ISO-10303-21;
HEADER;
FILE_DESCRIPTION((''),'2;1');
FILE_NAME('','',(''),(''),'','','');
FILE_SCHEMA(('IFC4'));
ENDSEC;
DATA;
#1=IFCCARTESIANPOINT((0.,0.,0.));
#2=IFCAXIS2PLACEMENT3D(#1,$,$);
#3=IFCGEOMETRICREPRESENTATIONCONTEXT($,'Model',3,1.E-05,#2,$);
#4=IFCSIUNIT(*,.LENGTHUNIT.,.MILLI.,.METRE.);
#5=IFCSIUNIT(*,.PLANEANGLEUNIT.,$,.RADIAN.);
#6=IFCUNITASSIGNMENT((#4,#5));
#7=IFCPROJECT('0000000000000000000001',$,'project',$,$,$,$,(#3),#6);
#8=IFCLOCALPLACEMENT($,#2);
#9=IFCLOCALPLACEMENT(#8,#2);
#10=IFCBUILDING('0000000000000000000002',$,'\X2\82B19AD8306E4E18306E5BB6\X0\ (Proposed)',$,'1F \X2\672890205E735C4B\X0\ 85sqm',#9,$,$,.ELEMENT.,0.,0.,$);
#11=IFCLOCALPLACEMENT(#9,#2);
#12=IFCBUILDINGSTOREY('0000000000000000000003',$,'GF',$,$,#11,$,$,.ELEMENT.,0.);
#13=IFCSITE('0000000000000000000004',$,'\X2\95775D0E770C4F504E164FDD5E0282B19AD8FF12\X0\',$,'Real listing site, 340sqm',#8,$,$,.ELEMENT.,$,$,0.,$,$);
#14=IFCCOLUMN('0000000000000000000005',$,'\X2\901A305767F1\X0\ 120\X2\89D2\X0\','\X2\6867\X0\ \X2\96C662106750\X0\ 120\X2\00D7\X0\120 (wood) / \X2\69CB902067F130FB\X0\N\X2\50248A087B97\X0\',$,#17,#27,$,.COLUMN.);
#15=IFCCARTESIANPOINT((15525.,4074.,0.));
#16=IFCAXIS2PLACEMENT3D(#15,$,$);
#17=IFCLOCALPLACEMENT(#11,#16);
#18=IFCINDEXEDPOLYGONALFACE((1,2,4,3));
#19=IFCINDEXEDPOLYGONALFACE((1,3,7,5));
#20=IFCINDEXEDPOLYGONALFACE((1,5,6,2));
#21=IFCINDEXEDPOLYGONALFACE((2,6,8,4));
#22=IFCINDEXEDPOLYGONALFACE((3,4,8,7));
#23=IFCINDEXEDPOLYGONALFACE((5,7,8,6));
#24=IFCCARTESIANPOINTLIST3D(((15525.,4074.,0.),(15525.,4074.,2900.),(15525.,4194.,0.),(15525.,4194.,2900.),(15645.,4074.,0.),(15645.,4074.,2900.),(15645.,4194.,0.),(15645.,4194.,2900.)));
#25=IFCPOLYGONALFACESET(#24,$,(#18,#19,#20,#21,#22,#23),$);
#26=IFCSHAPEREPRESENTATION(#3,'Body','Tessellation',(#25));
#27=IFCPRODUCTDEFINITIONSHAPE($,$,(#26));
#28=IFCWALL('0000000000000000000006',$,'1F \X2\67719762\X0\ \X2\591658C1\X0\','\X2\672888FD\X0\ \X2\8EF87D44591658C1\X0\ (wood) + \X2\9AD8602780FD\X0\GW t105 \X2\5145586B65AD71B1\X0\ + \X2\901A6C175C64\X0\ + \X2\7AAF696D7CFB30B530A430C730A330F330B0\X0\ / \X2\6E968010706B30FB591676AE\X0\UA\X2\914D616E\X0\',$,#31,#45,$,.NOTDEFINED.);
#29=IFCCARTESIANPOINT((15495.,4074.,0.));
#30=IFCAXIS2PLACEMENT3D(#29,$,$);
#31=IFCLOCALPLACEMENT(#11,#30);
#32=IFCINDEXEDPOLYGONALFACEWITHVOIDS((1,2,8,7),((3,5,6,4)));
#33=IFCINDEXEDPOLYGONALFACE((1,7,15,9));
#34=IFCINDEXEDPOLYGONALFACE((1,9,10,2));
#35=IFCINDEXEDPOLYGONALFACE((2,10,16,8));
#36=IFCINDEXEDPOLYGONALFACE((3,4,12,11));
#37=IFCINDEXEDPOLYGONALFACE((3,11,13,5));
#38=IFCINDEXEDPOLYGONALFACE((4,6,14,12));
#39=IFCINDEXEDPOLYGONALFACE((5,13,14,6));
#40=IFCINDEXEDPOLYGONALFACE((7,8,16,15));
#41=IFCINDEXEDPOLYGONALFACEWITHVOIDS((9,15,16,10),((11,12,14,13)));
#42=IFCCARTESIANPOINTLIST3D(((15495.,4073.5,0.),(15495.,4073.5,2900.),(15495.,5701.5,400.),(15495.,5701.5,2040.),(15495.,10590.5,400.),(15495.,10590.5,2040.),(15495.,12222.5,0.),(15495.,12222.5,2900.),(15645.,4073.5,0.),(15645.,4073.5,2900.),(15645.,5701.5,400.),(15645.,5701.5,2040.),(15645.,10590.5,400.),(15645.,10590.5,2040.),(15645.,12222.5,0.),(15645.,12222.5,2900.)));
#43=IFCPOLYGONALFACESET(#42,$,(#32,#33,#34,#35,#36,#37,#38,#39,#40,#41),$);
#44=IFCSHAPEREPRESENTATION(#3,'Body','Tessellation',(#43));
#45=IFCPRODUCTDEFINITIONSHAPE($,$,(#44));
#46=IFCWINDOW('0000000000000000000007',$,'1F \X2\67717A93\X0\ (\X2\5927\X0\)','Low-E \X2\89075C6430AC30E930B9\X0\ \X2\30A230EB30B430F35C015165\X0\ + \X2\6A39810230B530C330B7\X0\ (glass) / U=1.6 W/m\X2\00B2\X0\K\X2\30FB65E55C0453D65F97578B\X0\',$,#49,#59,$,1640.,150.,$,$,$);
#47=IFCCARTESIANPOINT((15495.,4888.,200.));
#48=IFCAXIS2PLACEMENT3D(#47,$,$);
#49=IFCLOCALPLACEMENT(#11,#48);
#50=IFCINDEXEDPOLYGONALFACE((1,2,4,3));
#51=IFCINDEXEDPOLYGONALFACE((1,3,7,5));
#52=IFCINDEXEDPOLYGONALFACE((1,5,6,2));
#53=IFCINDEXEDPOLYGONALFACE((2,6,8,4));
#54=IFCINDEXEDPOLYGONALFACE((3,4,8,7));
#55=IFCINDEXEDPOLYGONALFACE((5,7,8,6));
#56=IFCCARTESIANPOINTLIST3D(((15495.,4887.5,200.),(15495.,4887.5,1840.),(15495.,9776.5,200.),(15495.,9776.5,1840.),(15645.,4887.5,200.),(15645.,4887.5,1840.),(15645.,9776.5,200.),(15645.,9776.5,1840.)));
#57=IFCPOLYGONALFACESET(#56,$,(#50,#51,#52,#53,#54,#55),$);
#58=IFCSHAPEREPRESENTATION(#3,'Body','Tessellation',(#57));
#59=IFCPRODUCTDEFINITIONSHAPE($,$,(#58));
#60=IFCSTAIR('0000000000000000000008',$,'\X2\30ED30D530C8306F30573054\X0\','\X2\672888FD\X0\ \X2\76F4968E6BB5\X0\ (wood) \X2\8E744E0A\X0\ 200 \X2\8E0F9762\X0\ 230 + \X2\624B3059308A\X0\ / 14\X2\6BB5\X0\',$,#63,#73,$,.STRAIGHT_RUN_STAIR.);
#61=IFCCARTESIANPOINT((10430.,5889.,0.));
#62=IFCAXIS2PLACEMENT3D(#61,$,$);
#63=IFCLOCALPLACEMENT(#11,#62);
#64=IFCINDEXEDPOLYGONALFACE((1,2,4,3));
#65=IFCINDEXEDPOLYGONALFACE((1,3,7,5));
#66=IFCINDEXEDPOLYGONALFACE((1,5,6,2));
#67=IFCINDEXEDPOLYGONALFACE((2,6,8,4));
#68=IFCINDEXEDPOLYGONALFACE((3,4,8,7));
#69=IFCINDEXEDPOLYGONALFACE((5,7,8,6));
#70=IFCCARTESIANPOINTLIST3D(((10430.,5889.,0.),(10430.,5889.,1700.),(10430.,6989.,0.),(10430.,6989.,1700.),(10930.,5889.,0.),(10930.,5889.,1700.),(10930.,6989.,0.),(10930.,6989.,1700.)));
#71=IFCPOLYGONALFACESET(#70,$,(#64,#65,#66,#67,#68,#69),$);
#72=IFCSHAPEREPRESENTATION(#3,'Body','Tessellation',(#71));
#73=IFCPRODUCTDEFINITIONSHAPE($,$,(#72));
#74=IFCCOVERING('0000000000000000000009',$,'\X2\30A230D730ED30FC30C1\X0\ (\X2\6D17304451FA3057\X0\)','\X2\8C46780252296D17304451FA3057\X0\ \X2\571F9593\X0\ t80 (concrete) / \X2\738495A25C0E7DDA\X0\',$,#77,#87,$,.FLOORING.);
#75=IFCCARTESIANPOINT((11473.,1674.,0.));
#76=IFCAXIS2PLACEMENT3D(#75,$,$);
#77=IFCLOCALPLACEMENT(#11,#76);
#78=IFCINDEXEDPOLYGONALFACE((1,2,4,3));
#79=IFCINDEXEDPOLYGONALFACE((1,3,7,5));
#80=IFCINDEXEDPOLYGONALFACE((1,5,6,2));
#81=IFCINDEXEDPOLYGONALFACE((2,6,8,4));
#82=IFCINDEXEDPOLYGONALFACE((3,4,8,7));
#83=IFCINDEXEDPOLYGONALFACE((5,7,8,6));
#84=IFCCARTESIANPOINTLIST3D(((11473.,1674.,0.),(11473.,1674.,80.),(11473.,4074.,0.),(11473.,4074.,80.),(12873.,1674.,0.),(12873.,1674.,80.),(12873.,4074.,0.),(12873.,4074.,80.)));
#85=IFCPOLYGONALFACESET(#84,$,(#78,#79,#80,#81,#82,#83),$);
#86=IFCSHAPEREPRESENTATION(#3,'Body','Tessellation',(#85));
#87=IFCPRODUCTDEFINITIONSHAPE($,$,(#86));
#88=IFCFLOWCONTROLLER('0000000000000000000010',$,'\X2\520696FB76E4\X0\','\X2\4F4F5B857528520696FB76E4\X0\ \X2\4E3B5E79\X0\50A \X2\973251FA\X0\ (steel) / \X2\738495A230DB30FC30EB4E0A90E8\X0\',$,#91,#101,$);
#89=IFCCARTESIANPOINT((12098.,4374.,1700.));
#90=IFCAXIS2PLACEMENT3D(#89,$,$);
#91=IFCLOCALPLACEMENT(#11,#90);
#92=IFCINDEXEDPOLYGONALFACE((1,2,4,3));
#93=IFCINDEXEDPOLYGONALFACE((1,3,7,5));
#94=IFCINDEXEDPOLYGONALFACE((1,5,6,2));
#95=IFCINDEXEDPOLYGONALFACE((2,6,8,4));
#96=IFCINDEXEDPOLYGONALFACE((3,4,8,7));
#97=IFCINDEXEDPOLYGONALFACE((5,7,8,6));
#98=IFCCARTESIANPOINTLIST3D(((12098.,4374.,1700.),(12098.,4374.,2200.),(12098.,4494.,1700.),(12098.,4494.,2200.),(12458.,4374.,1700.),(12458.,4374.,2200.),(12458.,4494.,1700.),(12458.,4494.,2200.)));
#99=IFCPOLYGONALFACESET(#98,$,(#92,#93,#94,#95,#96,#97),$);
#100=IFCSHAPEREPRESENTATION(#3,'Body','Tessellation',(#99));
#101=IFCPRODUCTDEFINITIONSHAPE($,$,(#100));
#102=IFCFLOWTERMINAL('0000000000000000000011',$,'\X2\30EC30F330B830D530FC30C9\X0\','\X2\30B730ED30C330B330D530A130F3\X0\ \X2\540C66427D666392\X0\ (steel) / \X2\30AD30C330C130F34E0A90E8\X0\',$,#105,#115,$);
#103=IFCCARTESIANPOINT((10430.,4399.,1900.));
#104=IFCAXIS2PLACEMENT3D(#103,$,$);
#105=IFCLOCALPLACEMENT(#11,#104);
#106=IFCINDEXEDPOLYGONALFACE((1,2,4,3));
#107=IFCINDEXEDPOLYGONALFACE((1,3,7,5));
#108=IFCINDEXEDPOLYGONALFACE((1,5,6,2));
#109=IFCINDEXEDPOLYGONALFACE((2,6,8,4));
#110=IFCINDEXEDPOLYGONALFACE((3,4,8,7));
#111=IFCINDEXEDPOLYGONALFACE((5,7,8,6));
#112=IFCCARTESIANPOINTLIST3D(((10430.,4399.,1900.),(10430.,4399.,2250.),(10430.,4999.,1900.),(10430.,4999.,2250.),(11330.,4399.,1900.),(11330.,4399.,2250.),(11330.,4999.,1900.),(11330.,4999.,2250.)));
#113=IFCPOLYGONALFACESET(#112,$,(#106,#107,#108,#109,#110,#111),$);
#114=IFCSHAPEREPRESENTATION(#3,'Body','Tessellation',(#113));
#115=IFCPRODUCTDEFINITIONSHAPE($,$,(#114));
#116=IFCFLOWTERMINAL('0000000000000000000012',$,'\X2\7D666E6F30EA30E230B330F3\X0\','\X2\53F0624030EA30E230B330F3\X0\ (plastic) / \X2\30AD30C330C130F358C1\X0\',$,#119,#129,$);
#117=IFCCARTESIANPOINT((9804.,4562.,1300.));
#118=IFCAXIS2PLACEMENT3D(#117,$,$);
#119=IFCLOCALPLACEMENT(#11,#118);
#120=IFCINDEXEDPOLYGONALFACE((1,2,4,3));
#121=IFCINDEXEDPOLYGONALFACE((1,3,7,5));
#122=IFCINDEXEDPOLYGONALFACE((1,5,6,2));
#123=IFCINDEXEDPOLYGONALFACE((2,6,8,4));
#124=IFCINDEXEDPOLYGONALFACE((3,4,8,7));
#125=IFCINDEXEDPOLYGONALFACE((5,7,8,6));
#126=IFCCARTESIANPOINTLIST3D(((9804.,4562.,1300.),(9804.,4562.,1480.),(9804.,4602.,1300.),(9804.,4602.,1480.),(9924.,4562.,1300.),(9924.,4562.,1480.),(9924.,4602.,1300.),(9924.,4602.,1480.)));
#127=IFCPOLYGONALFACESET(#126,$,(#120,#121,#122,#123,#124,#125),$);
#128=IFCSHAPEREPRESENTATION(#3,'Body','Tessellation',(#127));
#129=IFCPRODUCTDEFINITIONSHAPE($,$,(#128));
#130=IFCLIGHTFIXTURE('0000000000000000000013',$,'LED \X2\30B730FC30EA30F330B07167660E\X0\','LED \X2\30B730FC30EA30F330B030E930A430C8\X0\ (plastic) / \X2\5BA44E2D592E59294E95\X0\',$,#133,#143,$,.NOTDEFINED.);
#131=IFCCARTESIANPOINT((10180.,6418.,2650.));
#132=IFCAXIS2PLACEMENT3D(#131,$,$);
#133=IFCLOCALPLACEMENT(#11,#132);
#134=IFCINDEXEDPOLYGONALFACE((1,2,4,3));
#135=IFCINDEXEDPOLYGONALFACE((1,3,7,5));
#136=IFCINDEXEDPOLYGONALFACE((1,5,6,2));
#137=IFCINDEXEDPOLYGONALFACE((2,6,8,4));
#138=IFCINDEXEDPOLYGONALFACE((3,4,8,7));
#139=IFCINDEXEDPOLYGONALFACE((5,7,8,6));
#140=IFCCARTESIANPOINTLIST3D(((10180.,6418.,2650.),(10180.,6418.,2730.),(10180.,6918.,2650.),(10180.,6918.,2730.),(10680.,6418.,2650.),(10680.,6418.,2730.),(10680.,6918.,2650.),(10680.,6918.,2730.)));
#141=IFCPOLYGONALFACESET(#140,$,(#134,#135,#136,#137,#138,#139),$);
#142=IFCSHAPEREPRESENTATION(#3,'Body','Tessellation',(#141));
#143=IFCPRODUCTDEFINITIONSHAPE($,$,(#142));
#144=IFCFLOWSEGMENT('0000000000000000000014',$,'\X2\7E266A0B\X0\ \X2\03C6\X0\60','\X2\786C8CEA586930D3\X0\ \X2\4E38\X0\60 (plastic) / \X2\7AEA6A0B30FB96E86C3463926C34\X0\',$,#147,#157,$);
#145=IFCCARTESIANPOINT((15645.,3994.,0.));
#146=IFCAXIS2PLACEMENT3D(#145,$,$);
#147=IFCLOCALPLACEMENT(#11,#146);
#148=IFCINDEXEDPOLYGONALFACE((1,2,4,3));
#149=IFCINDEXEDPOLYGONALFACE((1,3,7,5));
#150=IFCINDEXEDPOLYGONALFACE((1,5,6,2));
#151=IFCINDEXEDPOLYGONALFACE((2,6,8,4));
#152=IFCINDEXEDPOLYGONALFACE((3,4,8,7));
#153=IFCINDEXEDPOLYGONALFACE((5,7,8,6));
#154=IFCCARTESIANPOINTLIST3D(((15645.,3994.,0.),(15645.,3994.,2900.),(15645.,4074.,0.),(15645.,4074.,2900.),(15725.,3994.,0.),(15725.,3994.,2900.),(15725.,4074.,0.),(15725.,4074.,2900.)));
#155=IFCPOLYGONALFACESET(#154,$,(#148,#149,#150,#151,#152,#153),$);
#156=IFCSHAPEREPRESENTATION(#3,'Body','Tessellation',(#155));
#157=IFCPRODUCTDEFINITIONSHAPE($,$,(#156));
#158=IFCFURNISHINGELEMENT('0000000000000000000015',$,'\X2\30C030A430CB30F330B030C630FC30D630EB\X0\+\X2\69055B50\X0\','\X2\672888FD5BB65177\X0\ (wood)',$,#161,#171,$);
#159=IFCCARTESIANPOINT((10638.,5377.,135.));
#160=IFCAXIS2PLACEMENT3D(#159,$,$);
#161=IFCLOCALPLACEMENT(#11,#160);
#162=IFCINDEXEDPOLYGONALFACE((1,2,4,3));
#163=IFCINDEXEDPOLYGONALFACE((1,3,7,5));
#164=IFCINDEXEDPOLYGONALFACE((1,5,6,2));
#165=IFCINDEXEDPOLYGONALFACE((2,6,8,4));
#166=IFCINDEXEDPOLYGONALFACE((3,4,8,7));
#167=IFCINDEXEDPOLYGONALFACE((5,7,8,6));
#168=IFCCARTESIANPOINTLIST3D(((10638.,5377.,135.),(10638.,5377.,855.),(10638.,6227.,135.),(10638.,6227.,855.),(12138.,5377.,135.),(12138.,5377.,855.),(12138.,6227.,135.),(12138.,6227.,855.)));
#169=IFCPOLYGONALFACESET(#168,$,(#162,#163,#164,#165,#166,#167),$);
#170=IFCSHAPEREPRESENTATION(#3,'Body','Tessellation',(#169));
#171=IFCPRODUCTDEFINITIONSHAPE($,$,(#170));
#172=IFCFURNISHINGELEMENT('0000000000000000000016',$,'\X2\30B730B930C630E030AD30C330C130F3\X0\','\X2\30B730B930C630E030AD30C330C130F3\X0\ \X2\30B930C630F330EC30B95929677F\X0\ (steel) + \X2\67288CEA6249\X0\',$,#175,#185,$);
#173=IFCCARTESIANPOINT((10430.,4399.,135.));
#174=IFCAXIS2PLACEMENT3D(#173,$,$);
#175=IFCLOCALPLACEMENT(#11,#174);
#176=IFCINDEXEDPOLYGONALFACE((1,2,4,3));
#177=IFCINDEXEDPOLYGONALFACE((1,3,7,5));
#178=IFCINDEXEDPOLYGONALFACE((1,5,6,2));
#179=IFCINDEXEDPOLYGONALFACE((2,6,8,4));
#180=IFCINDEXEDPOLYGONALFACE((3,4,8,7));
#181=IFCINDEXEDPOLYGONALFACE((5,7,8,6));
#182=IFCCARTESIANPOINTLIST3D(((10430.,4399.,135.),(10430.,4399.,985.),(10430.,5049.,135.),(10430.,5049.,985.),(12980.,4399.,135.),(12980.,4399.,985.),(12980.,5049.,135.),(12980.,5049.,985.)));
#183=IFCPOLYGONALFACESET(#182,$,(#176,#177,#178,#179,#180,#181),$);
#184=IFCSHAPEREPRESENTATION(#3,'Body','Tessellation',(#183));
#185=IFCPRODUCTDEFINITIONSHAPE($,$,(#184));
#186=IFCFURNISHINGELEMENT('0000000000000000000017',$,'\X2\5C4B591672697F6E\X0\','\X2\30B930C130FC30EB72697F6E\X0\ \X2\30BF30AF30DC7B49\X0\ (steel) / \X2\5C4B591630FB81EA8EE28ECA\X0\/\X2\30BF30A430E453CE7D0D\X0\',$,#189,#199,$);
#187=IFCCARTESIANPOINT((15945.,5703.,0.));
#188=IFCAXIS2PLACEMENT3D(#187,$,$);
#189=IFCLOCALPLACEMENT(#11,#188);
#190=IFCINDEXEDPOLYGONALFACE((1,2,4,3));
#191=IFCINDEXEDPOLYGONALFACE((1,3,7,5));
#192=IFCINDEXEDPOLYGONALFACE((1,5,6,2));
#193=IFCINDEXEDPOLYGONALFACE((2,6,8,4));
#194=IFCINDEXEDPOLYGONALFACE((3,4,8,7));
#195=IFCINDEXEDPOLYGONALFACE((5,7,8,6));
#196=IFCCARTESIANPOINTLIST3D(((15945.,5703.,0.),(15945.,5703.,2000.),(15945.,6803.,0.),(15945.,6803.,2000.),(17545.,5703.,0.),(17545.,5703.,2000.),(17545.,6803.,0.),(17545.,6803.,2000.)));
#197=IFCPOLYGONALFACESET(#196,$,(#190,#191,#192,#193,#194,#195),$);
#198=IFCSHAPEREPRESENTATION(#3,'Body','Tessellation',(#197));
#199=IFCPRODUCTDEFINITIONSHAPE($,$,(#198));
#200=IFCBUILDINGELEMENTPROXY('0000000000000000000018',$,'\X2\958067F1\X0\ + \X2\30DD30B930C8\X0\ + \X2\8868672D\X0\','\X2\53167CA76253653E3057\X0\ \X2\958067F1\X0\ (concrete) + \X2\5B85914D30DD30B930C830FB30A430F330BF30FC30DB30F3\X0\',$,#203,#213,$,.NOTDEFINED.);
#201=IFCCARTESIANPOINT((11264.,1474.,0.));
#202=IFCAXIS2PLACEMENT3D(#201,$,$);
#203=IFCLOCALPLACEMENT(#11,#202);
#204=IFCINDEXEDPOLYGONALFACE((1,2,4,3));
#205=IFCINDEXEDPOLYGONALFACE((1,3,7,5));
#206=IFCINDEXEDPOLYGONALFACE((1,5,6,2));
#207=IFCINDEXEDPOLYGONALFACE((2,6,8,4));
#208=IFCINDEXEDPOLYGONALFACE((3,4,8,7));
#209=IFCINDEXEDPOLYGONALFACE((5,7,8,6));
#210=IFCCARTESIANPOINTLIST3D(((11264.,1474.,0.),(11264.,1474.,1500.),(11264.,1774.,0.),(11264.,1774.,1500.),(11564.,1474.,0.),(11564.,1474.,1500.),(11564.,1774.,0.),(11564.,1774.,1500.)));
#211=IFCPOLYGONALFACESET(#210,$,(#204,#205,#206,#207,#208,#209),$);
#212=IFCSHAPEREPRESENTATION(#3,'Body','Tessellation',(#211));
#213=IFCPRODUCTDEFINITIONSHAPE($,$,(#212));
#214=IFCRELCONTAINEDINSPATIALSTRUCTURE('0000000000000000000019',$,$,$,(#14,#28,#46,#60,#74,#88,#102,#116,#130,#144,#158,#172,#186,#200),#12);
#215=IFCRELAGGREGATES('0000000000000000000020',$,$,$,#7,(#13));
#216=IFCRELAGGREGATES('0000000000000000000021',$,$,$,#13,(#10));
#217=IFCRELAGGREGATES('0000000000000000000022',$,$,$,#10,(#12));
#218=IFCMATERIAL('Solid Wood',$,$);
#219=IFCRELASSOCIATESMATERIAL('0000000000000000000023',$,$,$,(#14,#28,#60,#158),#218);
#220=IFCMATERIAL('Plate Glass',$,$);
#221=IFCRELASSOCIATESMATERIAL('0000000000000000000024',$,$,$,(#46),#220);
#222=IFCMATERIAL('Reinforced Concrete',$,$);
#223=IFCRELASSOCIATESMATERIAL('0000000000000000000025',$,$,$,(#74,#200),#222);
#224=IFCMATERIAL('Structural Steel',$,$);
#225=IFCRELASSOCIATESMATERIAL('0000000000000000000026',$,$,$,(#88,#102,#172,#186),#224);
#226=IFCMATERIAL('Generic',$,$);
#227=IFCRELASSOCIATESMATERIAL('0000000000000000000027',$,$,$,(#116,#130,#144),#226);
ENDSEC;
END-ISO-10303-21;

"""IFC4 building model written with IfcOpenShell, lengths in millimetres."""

from ifc_helpers import new_model, si_unit, frame, frame_2d, origin, place, context, project, spatial, rectangle, extrude, material, element, fill, save


model = new_model("IFC4")

# Units and contexts
model_context = context("Model", 3, precision=1e-05, world=origin())
ifc_project = project(units=[si_unit("LENGTHUNIT", "METRE", prefix="MILLI"), si_unit("PLANEANGLEUNIT", "RADIAN")], contexts=[model_context])

# Site, building, storey
site_placement = place(None, origin())
site = spatial("IfcSite", under=ifc_project, at=site_placement, Name="長崎県佐世保市花高２", ObjectType="Real listing site, 340sqm", CompositionType="ELEMENT", RefElevation=0.0)
building_placement = place(site_placement, origin())
building = spatial("IfcBuilding", under=site, at=building_placement, Name="花高の丘の家 (Proposed)", ObjectType="1F 木造平屋 85sqm", CompositionType="ELEMENT", ElevationOfRefHeight=0.0, ElevationOfTerrain=0.0)
storey_placement = place(building_placement, origin())
storey = spatial("IfcBuildingStorey", under=building, at=storey_placement, Name="GF", CompositionType="ELEMENT", Elevation=0.0)

# Column
ifc_material_1 = material(Name="Solid Wood")
column_1_placement = place(storey_placement, frame((15525.0, 4074.0, 0.0)))
element("IfcColumn", 1, at=column_1_placement, inside=storey, material=ifc_material_1, Name="通し柱 120角", Description="桧 集成材 120×120 (wood) / 構造柱・N値計算", PredefinedType="COLUMN", context=model_context, shape_type="SweptSolid", body=[
    extrude(rectangle(XDim=120.0, YDim=120.0, at=frame_2d((60.0, 60.0))), frame((15525.0, 4074.0, 0.0)), (0.0, 0.0, 1.0), 2900.0),
])

# Wall, opening, window
wall_1_placement = place(storey_placement, frame((15495.0, 4074.0, 0.0)))
wall_1 = element("IfcWall", 2, at=wall_1_placement, inside=storey, material=ifc_material_1, Name="1F 東面 外壁", Description="木製 軸組外壁 (wood) + 高性能GW t105 充填断熱 + 通気層 + 窯業系サイディング / 準耐火・外皮UA配慮", PredefinedType="NOTDEFINED", context=model_context, shape_type="SweptSolid", body=[
    extrude(rectangle(XDim=150.0, YDim=8149.0, at=frame_2d((75.0, 4074.0))), frame((15495.0, 4074.0, 0.0)), (0.0, 0.0, 1.0), 2900.0),
])
opening_placement = place(storey_placement, frame((15495.0, 4888.0, 200.0)))
opening = element("IfcOpeningElement", 3, at=opening_placement, cuts=wall_1, PredefinedType="NOTDEFINED", context=model_context, shape_type="SweptSolid", body=[
    extrude(rectangle(XDim=150.0, YDim=4889.0, at=frame_2d((75.0, 2444.0))), frame((15495.0, 4888.0, 200.0)), (0.0, 0.0, 1.0), 1640.0),
])
ifc_material_2 = material(Name="Plate Glass")
window_placement = place(storey_placement, frame((15495.0, 4888.0, 200.0)))
window = element("IfcWindow", 4, at=window_placement, inside=storey, material=ifc_material_2, Name="1F 東窓 (大)", Description="Low-E 複層ガラス アルゴン封入 + 樹脂サッシ (glass) / U=1.6 W/m²K・日射取得型", OverallHeight=1640.0, OverallWidth=150.0, context=model_context, shape_type="SweptSolid", body=[
    extrude(rectangle(XDim=150.0, YDim=4889.0, at=frame_2d((75.0, 2444.0))), frame((15495.0, 4888.0, 200.0)), (0.0, 0.0, 1.0), 1640.0),
])
fill(opening, window)

# Stair
stair_placement = place(storey_placement, frame((10430.0, 5889.0, 0.0)))
element("IfcStair", 5, at=stair_placement, inside=storey, material=ifc_material_1, Name="ロフトはしご", Description="木製 直階段 (wood) 蹴上 200 踏面 230 + 手すり / 14段", PredefinedType="STRAIGHT_RUN_STAIR", context=model_context, shape_type="SweptSolid", body=[
    extrude(rectangle(XDim=500.0, YDim=1100.0, at=frame_2d((250.0, 550.0))), frame((10430.0, 5889.0, 0.0)), (0.0, 0.0, 1.0), 1700.0),
])

# Covering
ifc_material_3 = material(Name="Reinforced Concrete")
covering_placement = place(storey_placement, frame((11473.0, 1674.0, 0.0)))
element("IfcCovering", 6, at=covering_placement, inside=storey, material=ifc_material_3, Name="アプローチ (洗い出し)", Description="豆砂利洗い出し 土間 t80 (concrete) / 玄関導線", PredefinedType="FLOORING", context=model_context, shape_type="SweptSolid", body=[
    extrude(rectangle(XDim=1400.0, YDim=2400.0, at=frame_2d((700.0, 1200.0))), frame((11473.0, 1674.0, 0.0)), (0.0, 0.0, 1.0), 80.0),
])

# Flow controller
ifc_material_4 = material(Name="Structural Steel")
flow_controller_placement = place(storey_placement, frame((12098.0, 4374.0, 1700.0)))
element("IfcFlowController", 7, at=flow_controller_placement, inside=storey, material=ifc_material_4, Name="分電盤", Description="住宅用分電盤 主幹50A 露出 (steel) / 玄関ホール上部", context=model_context, shape_type="SweptSolid", body=[
    extrude(rectangle(XDim=360.0, YDim=120.0, at=frame_2d((180.0, 60.0))), frame((12098.0, 4374.0, 1700.0)), (0.0, 0.0, 1.0), 500.0),
])

# Flow terminals
flow_terminal_1_placement = place(storey_placement, frame((10430.0, 4399.0, 1900.0)))
element("IfcFlowTerminal", 8, at=flow_terminal_1_placement, inside=storey, material=ifc_material_4, Name="レンジフード", Description="シロッコファン 同時給排 (steel) / キッチン上部", context=model_context, shape_type="SweptSolid", body=[
    extrude(rectangle(XDim=900.0, YDim=600.0, at=frame_2d((450.0, 300.0))), frame((10430.0, 4399.0, 1900.0)), (0.0, 0.0, 1.0), 350.0),
])
ifc_material_5 = material(Name="Generic")
flow_terminal_2_placement = place(storey_placement, frame((9804.0, 4562.0, 1300.0)))
element("IfcFlowTerminal", 9, at=flow_terminal_2_placement, inside=storey, material=ifc_material_5, Name="給湯リモコン", Description="台所リモコン (plastic) / キッチン壁", context=model_context, shape_type="SweptSolid", body=[
    extrude(rectangle(XDim=120.0, YDim=40.0, at=frame_2d((60.0, 20.0))), frame((9804.0, 4562.0, 1300.0)), (0.0, 0.0, 1.0), 180.0),
])

# Light fixture
light_fixture_placement = place(storey_placement, frame((10180.0, 6418.0, 2650.0)))
element("IfcLightFixture", 10, at=light_fixture_placement, inside=storey, material=ifc_material_5, Name="LED シーリング照明", Description="LED シーリングライト (plastic) / 室中央天井", PredefinedType="NOTDEFINED", context=model_context, shape_type="SweptSolid", body=[
    extrude(rectangle(XDim=500.0, YDim=500.0, at=frame_2d((250.0, 250.0))), frame((10180.0, 6418.0, 2650.0)), (0.0, 0.0, 1.0), 80.0),
])

# Flow segment
flow_segment_placement = place(storey_placement, frame((15645.0, 3994.0, 0.0)))
element("IfcFlowSegment", 11, at=flow_segment_placement, inside=storey, material=ifc_material_5, Name="縦樋 φ60", Description="硬質塩ビ 丸60 (plastic) / 竪樋・雨水排水", context=model_context, shape_type="SweptSolid", body=[
    extrude(rectangle(XDim=80.0, YDim=80.0, at=frame_2d((40.0, 40.0))), frame((15645.0, 3994.0, 0.0)), (0.0, 0.0, 1.0), 2900.0),
])

# Furnishing elements
furnishing_1_placement = place(storey_placement, frame((10638.0, 5377.0, 135.0)))
element("IfcFurnishingElement", 12, at=furnishing_1_placement, inside=storey, material=ifc_material_1, Name="ダイニングテーブル+椅子", Description="木製家具 (wood)", context=model_context, shape_type="SweptSolid", body=[
    extrude(rectangle(XDim=1500.0, YDim=850.0, at=frame_2d((750.0, 425.0))), frame((10638.0, 5377.0, 135.0)), (0.0, 0.0, 1.0), 720.0),
])
furnishing_2_placement = place(storey_placement, frame((10430.0, 4399.0, 135.0)))
element("IfcFurnishingElement", 13, at=furnishing_2_placement, inside=storey, material=ifc_material_4, Name="システムキッチン", Description="システムキッチン ステンレス天板 (steel) + 木質扉", context=model_context, shape_type="SweptSolid", body=[
    extrude(rectangle(XDim=2550.0, YDim=650.0, at=frame_2d((1275.0, 325.0))), frame((10430.0, 4399.0, 135.0)), (0.0, 0.0, 1.0), 850.0),
])
furnishing_3_placement = place(storey_placement, frame((15945.0, 5703.0, 0.0)))
element("IfcFurnishingElement", 14, at=furnishing_3_placement, inside=storey, material=ifc_material_4, Name="屋外物置", Description="スチール物置 タクボ等 (steel) / 屋外・自転車/タイヤ収納", context=model_context, shape_type="SweptSolid", body=[
    extrude(rectangle(XDim=1600.0, YDim=1100.0, at=frame_2d((800.0, 550.0))), frame((15945.0, 5703.0, 0.0)), (0.0, 0.0, 1.0), 2000.0),
])

# Building element proxy
proxy_placement = place(storey_placement, frame((11264.0, 1474.0, 0.0)))
element("IfcBuildingElementProxy", 15, at=proxy_placement, inside=storey, material=ifc_material_3, Name="門柱 + ポスト + 表札", Description="化粧打放し 門柱 (concrete) + 宅配ポスト・インターホン", PredefinedType="NOTDEFINED", context=model_context, shape_type="SweptSolid", body=[
    extrude(rectangle(XDim=300.0, YDim=300.0, at=frame_2d((150.0, 150.0))), frame((11264.0, 1474.0, 0.0)), (0.0, 0.0, 1.0), 1500.0),
])

save(model, "model.ifc")
